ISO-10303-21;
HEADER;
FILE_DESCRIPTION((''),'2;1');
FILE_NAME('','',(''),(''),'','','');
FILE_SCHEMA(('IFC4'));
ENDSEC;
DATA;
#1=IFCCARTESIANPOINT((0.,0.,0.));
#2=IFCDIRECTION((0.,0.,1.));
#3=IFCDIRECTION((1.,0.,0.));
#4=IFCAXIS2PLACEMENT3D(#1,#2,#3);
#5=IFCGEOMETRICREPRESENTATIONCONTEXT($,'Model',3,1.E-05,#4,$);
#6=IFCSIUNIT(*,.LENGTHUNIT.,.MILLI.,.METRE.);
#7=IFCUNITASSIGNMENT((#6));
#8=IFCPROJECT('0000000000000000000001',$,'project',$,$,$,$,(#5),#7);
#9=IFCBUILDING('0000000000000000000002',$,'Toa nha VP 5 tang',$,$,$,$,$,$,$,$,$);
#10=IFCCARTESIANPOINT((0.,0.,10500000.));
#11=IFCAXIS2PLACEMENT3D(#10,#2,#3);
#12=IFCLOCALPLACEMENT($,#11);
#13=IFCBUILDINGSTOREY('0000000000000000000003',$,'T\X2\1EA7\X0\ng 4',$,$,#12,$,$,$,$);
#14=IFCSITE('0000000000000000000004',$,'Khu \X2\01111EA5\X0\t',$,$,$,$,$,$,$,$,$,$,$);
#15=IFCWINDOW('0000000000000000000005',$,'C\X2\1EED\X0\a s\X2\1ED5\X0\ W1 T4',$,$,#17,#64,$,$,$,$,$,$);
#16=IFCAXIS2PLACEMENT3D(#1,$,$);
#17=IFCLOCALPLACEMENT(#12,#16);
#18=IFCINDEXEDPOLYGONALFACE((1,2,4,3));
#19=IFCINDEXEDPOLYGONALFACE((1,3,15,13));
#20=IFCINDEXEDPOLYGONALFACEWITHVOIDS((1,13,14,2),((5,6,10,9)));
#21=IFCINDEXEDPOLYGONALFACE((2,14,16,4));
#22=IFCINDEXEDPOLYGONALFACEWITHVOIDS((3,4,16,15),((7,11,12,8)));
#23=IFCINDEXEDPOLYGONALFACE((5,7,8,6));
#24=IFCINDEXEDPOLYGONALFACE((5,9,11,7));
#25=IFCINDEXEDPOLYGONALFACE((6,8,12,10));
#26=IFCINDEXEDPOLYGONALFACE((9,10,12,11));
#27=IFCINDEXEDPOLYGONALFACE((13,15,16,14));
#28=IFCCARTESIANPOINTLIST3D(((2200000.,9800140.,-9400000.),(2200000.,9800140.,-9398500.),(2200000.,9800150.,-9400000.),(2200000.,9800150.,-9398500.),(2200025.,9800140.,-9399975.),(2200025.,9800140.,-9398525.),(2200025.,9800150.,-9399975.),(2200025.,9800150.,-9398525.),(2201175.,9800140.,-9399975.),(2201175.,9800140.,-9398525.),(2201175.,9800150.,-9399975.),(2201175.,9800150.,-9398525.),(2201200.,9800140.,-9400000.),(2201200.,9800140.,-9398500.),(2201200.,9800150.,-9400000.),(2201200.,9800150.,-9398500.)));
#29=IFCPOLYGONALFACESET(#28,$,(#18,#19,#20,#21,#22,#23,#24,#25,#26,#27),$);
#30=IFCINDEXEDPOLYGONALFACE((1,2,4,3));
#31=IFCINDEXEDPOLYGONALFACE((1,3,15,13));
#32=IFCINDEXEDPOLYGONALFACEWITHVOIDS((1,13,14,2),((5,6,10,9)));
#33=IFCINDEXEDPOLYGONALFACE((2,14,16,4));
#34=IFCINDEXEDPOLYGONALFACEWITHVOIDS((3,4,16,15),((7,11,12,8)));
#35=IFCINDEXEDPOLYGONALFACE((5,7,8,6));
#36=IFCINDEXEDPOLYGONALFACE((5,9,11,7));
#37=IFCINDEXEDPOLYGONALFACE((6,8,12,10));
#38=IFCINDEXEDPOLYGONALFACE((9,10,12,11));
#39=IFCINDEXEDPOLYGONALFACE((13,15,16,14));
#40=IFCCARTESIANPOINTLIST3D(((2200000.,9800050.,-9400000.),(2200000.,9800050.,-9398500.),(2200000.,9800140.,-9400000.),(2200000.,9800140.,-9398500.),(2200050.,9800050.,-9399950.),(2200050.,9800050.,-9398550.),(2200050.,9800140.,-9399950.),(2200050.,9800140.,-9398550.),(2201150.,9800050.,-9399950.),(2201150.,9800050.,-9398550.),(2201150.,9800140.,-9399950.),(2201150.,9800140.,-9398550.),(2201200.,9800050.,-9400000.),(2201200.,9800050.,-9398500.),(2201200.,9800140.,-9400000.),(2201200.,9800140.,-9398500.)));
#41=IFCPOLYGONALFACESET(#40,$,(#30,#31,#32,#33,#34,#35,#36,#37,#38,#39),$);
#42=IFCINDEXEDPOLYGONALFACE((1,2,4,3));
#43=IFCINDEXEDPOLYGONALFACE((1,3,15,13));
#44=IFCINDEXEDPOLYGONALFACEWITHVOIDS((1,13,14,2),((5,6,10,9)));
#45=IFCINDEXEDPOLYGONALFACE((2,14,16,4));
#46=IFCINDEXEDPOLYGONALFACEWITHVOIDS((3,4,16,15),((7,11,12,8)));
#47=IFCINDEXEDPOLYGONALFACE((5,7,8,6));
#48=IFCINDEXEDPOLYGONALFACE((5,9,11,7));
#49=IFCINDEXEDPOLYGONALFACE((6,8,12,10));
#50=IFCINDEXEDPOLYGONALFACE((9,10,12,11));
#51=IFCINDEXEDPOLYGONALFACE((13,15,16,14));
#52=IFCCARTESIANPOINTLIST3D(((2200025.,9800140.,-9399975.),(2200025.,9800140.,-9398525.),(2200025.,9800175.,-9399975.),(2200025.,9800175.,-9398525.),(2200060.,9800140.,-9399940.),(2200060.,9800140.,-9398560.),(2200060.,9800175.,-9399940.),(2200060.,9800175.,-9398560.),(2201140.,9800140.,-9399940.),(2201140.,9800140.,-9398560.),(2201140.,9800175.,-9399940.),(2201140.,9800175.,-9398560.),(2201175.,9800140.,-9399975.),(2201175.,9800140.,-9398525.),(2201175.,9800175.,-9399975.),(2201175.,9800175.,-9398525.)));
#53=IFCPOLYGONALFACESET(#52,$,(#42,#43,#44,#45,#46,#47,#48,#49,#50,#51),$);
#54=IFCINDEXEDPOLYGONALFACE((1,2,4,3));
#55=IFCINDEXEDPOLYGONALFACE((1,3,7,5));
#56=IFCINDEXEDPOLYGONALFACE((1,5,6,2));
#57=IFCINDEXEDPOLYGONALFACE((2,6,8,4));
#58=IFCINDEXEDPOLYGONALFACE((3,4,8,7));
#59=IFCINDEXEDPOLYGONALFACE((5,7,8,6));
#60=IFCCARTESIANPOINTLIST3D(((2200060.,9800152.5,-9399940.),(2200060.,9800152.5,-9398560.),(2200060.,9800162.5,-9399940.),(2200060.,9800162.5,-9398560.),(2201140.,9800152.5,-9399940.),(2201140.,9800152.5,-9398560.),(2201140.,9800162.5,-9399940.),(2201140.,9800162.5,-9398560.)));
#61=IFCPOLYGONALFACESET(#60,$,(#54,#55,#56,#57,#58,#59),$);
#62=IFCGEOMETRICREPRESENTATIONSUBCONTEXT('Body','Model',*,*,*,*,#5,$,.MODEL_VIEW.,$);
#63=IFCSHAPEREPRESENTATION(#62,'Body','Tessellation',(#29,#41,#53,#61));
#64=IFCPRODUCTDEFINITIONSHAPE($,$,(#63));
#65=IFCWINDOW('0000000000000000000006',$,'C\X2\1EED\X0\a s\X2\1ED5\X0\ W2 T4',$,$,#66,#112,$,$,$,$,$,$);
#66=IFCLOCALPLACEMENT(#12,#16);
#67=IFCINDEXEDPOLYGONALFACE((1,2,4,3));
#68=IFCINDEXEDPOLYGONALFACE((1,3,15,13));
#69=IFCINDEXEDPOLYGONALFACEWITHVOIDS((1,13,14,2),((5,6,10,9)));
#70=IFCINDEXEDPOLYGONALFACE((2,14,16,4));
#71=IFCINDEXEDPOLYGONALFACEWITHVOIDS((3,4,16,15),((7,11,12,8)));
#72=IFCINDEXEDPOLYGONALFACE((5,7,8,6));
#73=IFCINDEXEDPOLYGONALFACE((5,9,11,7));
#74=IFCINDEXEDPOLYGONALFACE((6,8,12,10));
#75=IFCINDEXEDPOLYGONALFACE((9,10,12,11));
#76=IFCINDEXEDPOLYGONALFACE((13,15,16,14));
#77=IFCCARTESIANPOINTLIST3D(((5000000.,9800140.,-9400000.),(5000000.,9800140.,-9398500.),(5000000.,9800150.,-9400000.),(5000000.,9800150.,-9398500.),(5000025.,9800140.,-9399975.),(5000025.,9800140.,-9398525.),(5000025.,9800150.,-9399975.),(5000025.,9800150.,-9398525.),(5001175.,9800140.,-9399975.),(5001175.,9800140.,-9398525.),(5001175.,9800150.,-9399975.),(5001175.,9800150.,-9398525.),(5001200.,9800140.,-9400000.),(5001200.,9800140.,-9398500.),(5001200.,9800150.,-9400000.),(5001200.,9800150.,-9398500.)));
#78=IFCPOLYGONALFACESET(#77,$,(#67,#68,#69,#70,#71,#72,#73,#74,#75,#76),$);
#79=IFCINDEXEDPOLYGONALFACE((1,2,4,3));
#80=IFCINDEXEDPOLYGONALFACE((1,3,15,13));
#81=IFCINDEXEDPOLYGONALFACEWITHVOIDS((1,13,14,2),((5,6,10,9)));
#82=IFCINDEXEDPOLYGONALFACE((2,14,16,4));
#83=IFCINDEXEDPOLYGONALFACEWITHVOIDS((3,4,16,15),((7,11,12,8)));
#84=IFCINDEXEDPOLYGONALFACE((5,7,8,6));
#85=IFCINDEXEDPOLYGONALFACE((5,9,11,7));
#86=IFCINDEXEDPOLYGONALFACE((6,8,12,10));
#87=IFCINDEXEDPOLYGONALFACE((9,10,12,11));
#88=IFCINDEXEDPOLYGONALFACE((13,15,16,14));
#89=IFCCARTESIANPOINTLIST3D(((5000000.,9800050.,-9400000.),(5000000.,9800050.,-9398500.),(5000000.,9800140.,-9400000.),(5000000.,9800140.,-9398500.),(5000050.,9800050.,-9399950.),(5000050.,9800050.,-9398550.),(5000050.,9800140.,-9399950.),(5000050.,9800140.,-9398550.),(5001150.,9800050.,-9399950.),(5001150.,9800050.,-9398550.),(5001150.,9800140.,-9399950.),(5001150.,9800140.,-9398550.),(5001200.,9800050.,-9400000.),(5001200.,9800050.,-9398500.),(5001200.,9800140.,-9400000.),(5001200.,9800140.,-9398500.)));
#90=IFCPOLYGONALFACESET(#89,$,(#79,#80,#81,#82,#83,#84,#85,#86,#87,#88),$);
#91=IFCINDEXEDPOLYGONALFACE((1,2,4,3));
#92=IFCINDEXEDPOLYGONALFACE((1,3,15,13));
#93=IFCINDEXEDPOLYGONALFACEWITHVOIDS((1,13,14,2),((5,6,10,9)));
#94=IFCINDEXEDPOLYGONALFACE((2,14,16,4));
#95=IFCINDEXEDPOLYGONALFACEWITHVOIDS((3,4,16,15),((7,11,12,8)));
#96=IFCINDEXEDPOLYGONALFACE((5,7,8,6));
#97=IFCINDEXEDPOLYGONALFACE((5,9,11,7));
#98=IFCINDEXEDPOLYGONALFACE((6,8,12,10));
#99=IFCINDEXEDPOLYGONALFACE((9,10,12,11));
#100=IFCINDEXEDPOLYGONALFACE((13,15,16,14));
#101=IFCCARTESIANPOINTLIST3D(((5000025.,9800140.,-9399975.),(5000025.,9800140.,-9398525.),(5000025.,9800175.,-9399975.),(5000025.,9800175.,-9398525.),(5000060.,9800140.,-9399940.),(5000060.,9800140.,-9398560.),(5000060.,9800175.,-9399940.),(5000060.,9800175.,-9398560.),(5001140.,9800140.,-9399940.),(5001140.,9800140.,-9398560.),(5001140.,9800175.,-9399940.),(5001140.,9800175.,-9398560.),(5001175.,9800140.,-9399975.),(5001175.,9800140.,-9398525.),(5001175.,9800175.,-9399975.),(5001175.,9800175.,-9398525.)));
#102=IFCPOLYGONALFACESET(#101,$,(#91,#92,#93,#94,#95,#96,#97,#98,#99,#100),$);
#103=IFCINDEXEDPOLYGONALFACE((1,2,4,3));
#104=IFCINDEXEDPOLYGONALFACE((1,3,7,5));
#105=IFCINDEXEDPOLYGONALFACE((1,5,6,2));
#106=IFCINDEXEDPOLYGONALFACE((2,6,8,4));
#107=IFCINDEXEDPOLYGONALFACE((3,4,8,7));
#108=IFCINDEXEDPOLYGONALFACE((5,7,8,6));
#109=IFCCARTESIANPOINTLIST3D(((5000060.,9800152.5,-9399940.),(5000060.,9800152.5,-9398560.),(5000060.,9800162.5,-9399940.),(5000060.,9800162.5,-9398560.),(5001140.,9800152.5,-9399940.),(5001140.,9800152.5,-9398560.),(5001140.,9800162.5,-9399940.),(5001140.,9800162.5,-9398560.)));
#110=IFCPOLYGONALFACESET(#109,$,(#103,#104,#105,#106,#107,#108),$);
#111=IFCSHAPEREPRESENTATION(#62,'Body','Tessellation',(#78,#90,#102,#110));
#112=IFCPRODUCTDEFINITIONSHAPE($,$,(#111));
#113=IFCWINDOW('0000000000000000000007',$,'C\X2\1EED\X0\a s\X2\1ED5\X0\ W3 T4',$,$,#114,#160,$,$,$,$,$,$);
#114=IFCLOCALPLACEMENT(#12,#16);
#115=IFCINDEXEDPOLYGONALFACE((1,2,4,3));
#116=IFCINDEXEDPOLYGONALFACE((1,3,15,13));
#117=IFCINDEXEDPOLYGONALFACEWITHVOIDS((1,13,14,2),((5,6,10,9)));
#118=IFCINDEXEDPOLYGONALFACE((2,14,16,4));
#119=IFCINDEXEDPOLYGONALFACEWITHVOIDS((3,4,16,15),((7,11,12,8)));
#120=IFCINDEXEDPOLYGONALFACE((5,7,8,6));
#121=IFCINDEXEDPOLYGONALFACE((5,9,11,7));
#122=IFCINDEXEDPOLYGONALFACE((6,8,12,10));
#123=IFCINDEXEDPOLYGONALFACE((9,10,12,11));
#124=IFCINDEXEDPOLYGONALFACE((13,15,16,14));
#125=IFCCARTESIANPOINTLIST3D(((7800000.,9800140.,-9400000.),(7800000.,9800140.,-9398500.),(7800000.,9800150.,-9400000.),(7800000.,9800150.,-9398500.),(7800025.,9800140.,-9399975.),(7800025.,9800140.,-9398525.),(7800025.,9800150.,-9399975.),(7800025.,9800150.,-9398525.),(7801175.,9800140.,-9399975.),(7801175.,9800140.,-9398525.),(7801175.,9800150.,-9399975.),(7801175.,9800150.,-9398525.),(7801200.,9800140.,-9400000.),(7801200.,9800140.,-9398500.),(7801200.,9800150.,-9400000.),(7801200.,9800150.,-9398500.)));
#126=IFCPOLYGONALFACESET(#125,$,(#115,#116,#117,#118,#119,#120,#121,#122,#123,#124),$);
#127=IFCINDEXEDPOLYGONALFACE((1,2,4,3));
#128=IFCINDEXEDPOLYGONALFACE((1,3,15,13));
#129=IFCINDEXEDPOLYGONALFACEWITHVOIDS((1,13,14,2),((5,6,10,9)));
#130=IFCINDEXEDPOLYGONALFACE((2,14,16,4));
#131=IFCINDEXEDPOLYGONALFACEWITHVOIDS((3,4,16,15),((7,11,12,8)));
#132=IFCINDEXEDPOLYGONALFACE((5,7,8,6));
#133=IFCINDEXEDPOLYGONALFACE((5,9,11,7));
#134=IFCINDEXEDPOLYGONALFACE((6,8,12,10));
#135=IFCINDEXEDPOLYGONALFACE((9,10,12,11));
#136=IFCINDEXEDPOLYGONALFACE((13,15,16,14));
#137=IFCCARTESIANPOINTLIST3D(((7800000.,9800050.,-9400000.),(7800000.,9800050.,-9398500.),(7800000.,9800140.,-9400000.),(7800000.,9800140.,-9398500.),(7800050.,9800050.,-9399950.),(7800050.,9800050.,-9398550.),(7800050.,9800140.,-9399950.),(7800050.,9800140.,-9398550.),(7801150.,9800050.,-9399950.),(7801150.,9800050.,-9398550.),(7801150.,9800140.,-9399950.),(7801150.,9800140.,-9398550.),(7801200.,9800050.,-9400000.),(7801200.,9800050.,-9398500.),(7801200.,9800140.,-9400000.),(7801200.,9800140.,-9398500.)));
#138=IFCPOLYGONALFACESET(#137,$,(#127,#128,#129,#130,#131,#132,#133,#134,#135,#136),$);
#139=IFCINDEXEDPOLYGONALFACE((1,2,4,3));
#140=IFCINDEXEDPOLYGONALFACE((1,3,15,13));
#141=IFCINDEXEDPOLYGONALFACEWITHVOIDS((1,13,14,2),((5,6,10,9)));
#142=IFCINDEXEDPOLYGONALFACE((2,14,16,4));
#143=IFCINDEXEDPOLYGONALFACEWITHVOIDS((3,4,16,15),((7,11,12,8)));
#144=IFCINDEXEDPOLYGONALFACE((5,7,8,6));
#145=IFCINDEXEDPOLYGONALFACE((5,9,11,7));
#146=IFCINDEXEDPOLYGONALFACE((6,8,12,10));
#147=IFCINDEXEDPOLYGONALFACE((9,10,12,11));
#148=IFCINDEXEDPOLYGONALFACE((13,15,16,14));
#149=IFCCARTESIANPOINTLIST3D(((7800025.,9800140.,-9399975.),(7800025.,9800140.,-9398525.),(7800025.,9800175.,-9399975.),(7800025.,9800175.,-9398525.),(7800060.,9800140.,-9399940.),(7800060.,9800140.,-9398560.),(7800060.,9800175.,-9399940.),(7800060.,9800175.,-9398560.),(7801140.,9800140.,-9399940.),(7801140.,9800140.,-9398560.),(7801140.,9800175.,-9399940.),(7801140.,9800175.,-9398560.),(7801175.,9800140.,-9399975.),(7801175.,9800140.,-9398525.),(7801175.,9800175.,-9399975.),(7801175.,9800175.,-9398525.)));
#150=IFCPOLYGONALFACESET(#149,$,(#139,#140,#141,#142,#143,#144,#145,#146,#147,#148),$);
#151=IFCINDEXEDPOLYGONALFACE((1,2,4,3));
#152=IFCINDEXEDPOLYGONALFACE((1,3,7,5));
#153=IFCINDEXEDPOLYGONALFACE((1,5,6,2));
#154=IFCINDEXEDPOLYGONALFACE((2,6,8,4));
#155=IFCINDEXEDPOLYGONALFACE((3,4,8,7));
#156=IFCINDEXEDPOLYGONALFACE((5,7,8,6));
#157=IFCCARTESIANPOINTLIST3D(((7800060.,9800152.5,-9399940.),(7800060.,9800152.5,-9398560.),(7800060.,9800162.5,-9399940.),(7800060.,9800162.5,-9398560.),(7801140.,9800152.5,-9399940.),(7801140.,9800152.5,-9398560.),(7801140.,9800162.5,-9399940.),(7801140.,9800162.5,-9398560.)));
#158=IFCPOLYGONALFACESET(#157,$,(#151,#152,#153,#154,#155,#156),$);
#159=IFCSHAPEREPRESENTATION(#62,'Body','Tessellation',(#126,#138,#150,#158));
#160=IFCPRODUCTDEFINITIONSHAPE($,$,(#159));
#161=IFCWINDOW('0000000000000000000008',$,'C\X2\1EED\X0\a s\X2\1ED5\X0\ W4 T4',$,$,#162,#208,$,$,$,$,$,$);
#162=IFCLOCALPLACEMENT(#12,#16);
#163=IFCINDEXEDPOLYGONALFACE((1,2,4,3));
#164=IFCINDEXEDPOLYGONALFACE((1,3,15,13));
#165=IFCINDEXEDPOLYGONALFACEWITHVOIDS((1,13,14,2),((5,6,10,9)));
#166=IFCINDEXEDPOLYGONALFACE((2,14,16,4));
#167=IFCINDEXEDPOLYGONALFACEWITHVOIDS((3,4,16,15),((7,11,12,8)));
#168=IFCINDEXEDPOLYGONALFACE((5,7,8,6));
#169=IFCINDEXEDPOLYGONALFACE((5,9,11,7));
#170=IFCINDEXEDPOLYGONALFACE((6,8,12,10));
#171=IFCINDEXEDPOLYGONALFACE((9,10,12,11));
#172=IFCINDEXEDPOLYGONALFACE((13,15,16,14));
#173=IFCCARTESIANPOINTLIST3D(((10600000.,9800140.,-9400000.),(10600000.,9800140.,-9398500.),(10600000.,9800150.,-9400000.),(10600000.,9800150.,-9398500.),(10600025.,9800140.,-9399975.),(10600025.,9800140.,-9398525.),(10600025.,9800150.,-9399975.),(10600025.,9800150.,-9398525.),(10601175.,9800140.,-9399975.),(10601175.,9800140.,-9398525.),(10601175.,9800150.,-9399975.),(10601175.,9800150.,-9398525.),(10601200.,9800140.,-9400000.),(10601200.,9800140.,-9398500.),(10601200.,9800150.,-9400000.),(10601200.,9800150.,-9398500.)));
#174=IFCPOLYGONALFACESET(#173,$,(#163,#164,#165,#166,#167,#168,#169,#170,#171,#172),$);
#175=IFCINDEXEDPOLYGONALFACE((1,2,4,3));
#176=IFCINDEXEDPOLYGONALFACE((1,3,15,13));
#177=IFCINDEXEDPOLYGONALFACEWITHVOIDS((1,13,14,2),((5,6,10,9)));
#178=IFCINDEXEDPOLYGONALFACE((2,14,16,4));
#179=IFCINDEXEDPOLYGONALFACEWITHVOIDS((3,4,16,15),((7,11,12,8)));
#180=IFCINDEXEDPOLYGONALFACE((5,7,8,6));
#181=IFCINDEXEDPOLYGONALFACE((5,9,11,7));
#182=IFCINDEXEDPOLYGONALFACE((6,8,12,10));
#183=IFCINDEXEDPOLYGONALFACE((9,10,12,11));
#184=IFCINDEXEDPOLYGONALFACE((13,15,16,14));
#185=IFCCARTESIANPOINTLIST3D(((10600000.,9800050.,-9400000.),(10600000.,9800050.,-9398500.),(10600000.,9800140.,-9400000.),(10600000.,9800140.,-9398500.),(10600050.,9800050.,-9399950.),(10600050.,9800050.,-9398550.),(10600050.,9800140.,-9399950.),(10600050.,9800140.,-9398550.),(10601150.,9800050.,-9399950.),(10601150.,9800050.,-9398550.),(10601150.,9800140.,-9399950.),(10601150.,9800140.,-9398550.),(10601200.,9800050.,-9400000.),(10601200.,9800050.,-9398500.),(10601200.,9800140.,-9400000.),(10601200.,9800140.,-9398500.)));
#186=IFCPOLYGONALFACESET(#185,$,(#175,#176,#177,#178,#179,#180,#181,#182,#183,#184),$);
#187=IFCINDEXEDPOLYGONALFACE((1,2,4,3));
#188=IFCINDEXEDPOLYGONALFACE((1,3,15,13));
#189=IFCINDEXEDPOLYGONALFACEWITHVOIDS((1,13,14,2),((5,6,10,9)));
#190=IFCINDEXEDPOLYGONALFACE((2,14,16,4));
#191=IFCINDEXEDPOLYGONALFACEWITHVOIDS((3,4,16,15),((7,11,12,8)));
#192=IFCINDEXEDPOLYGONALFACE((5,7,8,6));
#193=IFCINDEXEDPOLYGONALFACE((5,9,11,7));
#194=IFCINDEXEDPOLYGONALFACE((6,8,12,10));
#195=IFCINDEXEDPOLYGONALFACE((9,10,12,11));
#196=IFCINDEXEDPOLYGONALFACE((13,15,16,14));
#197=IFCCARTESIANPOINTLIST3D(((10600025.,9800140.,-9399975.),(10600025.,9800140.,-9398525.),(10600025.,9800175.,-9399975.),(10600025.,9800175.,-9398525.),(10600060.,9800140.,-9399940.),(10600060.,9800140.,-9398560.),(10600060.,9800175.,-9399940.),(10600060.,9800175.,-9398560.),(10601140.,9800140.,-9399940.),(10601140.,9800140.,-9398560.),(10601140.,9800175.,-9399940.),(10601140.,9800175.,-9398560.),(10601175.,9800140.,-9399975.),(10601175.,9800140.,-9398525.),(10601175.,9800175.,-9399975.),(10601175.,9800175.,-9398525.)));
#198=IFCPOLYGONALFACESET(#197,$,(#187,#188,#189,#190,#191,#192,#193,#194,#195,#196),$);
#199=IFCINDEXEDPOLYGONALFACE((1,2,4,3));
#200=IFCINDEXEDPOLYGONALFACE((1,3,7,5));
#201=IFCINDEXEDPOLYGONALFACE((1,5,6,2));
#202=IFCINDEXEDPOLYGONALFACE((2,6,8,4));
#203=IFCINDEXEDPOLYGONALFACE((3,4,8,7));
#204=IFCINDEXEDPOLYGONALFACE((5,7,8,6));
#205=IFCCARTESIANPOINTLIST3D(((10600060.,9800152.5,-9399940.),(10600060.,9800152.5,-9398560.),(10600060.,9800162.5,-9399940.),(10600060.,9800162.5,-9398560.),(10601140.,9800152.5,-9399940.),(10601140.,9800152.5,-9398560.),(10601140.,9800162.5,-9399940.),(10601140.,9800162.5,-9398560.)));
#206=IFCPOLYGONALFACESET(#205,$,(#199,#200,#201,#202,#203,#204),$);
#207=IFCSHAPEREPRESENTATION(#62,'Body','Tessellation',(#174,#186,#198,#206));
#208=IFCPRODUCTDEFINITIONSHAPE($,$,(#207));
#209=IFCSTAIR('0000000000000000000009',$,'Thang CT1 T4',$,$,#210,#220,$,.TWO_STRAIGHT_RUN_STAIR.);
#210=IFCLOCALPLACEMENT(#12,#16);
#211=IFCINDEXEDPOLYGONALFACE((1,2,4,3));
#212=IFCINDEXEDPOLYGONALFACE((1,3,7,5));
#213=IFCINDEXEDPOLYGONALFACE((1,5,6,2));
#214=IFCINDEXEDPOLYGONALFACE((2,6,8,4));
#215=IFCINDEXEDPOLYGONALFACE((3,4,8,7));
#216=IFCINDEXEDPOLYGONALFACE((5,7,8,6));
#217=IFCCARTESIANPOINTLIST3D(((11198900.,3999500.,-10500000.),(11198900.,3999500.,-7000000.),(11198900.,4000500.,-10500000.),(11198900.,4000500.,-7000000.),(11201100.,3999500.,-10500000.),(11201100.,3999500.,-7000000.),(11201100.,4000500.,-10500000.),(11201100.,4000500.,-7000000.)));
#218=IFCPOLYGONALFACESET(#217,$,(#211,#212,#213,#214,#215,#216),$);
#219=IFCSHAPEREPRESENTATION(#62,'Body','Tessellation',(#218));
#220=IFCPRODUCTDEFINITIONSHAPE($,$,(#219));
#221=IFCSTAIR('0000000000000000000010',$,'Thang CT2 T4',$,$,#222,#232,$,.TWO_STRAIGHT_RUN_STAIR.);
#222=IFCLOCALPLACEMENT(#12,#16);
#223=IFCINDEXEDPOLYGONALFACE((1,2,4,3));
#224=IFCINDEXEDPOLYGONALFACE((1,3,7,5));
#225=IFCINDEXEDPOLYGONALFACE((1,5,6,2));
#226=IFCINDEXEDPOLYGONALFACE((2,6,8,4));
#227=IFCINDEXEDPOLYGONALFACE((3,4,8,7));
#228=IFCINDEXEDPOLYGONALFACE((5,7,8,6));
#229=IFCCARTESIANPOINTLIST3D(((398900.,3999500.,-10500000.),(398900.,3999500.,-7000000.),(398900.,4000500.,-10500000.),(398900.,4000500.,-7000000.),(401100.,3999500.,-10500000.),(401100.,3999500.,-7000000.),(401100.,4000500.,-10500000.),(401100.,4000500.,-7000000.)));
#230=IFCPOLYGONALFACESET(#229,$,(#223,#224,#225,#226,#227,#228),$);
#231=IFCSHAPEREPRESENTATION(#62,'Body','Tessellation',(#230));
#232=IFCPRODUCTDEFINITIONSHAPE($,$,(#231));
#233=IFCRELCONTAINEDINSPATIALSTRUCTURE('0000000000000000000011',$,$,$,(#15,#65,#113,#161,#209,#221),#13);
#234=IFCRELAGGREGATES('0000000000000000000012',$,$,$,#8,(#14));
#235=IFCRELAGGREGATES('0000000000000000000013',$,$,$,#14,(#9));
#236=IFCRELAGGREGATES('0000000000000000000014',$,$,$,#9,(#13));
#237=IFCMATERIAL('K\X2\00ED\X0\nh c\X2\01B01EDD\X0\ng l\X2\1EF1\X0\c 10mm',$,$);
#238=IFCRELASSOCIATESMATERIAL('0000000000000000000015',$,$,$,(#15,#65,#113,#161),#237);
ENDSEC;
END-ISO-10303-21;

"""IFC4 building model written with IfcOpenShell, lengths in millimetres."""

from ifc_helpers import new_model, entity, si_unit, frame, origin_with_axes, place, context, subcontext, project, spatial, line, indexed_curve, outline, extrude, material, element, save


model = new_model("IFC4")

# Units and contexts
model_context = context("Model", 3, precision=1e-05, world=origin_with_axes())
body_context = subcontext(model_context, "Body", "Model", "MODEL_VIEW")
ifc_project = project(units=[si_unit("LENGTHUNIT", "METRE", prefix="MILLI")], contexts=[model_context])

# Site, building, storey
site = spatial("IfcSite", under=ifc_project, Name="Khu đất")
building = spatial("IfcBuilding", under=site, Name="Toa nha VP 5 tang")
storey_placement = place(None, frame((0.0, 0.0, 10500000.0), z_axis=(0.0, 0.0, 1.0), x_axis=(1.0, 0.0, 0.0)))
storey = spatial("IfcBuildingStorey", under=building, at=storey_placement, Name="Tầng 4")

# Windows
ifc_material_1 = material(Name="Kính cường lực 10mm")
for number, where, z_axis, x_axis, name in (
    (1, (2200000.0, 9800000.0, -9400000.0), (0.0, 0.0, 1.0), (1.0, 0.0, 0.0), "Cửa sổ W1 T4"),
    (2, (5000000.0, 9800000.0, -9400000.0), (0.0, 0.0, 1.0), (1.0, 0.0, 0.0), "Cửa sổ W2 T4"),
    (3, (7800000.0, 9800000.0, -9400000.0), (0.0, 0.0, 1.0), (1.0, 0.0, 0.0), "Cửa sổ W3 T4"),
    (4, (10600000.0, 9800000.0, -9400000.0), (0.0, 0.0, 1.0), (1.0, 0.0, 0.0), "Cửa sổ W4 T4"),
):
    element("IfcWindow", number, at=place(storey_placement, frame(where, z_axis=z_axis, x_axis=x_axis)), inside=storey, material=ifc_material_1, Name=name, context=body_context, shape_type="SolidModel", body=[
        extrude(outline(indexed_curve([(0.0, 0.0), (1200.0, 0.0), (1200.0, 1500.0), (0.0, 1500.0)], segments=[line(1, 2, 3, 4, 1)]), holes=[indexed_curve([(25.0, 25.0), (1175.0, 25.0), (1175.0, 1475.0), (25.0, 1475.0)], segments=[line(1, 2, 3, 4, 1)])]), frame((0.0, 140.0, 0.0), z_axis=(0.0, -1.0, 0.0), x_axis=(1.0, 0.0, 0.0)), (0.0, 0.0, -1.0), 10.0),
        extrude(outline(indexed_curve([(0.0, 0.0), (1200.0, 0.0), (1200.0, 1500.0), (0.0, 1500.0)], segments=[line(1, 2, 3, 4, 1)]), holes=[indexed_curve([(50.0, 50.0), (1150.0, 50.0), (1150.0, 1450.0), (50.0, 1450.0)], segments=[line(1, 2, 3, 4, 1)])]), frame((0.0, 50.0, 0.0), z_axis=(0.0, -1.0, 0.0), x_axis=(1.0, 0.0, 0.0)), (0.0, 0.0, -1.0), 90.0),
        extrude(outline(indexed_curve([(0.0, 0.0), (1150.0, 0.0), (1150.0, 1450.0), (0.0, 1450.0)], segments=[line(1, 2, 3, 4, 1)]), holes=[indexed_curve([(35.0, 35.0), (1115.0, 35.0), (1115.0, 1415.0), (35.0, 1415.0)], segments=[line(1, 2, 3, 4, 1)])]), frame((25.0, 140.0, 25.0), z_axis=(0.0, -1.0, 0.0), x_axis=(1.0, 0.0, 0.0)), (0.0, 0.0, -1.0), 35.0),
        extrude(outline(indexed_curve([(35.0, 35.0), (1115.0, 35.0), (1115.0, 1415.0), (35.0, 1415.0)], segments=[line(1, 2, 3, 4, 1)])), frame((25.0, 152.5, 25.0), z_axis=(0.0, -1.0, 0.0), x_axis=(1.0, 0.0, 0.0)), (0.0, 0.0, -1.0), 10.0),
    ])

# Stairs
for number, where, z_axis, x_axis, name in (
    (5, (11200000.0, 4000000.0, -10500000.0), (0.0, 0.0, 1.0), (1.0, 0.0, 0.0), "Thang CT1 T4"),
    (6, (400000.0, 4000000.0, -10500000.0), (0.0, 0.0, 1.0), (1.0, 0.0, 0.0), "Thang CT2 T4"),
):
    element("IfcStair", number, at=place(storey_placement, frame(where, z_axis=z_axis, x_axis=x_axis)), inside=storey, Name=name, PredefinedType="TWO_STRAIGHT_RUN_STAIR", context=body_context, shape_type="SweptSolid", body=[
        extrude(entity("IfcRectangleProfileDef", None, None, None, 2200.0, 1000.0), origin_with_axes(), (0.0, 0.0, 1.0), 3500000.0),
    ])

save(model, "model.ifc")
